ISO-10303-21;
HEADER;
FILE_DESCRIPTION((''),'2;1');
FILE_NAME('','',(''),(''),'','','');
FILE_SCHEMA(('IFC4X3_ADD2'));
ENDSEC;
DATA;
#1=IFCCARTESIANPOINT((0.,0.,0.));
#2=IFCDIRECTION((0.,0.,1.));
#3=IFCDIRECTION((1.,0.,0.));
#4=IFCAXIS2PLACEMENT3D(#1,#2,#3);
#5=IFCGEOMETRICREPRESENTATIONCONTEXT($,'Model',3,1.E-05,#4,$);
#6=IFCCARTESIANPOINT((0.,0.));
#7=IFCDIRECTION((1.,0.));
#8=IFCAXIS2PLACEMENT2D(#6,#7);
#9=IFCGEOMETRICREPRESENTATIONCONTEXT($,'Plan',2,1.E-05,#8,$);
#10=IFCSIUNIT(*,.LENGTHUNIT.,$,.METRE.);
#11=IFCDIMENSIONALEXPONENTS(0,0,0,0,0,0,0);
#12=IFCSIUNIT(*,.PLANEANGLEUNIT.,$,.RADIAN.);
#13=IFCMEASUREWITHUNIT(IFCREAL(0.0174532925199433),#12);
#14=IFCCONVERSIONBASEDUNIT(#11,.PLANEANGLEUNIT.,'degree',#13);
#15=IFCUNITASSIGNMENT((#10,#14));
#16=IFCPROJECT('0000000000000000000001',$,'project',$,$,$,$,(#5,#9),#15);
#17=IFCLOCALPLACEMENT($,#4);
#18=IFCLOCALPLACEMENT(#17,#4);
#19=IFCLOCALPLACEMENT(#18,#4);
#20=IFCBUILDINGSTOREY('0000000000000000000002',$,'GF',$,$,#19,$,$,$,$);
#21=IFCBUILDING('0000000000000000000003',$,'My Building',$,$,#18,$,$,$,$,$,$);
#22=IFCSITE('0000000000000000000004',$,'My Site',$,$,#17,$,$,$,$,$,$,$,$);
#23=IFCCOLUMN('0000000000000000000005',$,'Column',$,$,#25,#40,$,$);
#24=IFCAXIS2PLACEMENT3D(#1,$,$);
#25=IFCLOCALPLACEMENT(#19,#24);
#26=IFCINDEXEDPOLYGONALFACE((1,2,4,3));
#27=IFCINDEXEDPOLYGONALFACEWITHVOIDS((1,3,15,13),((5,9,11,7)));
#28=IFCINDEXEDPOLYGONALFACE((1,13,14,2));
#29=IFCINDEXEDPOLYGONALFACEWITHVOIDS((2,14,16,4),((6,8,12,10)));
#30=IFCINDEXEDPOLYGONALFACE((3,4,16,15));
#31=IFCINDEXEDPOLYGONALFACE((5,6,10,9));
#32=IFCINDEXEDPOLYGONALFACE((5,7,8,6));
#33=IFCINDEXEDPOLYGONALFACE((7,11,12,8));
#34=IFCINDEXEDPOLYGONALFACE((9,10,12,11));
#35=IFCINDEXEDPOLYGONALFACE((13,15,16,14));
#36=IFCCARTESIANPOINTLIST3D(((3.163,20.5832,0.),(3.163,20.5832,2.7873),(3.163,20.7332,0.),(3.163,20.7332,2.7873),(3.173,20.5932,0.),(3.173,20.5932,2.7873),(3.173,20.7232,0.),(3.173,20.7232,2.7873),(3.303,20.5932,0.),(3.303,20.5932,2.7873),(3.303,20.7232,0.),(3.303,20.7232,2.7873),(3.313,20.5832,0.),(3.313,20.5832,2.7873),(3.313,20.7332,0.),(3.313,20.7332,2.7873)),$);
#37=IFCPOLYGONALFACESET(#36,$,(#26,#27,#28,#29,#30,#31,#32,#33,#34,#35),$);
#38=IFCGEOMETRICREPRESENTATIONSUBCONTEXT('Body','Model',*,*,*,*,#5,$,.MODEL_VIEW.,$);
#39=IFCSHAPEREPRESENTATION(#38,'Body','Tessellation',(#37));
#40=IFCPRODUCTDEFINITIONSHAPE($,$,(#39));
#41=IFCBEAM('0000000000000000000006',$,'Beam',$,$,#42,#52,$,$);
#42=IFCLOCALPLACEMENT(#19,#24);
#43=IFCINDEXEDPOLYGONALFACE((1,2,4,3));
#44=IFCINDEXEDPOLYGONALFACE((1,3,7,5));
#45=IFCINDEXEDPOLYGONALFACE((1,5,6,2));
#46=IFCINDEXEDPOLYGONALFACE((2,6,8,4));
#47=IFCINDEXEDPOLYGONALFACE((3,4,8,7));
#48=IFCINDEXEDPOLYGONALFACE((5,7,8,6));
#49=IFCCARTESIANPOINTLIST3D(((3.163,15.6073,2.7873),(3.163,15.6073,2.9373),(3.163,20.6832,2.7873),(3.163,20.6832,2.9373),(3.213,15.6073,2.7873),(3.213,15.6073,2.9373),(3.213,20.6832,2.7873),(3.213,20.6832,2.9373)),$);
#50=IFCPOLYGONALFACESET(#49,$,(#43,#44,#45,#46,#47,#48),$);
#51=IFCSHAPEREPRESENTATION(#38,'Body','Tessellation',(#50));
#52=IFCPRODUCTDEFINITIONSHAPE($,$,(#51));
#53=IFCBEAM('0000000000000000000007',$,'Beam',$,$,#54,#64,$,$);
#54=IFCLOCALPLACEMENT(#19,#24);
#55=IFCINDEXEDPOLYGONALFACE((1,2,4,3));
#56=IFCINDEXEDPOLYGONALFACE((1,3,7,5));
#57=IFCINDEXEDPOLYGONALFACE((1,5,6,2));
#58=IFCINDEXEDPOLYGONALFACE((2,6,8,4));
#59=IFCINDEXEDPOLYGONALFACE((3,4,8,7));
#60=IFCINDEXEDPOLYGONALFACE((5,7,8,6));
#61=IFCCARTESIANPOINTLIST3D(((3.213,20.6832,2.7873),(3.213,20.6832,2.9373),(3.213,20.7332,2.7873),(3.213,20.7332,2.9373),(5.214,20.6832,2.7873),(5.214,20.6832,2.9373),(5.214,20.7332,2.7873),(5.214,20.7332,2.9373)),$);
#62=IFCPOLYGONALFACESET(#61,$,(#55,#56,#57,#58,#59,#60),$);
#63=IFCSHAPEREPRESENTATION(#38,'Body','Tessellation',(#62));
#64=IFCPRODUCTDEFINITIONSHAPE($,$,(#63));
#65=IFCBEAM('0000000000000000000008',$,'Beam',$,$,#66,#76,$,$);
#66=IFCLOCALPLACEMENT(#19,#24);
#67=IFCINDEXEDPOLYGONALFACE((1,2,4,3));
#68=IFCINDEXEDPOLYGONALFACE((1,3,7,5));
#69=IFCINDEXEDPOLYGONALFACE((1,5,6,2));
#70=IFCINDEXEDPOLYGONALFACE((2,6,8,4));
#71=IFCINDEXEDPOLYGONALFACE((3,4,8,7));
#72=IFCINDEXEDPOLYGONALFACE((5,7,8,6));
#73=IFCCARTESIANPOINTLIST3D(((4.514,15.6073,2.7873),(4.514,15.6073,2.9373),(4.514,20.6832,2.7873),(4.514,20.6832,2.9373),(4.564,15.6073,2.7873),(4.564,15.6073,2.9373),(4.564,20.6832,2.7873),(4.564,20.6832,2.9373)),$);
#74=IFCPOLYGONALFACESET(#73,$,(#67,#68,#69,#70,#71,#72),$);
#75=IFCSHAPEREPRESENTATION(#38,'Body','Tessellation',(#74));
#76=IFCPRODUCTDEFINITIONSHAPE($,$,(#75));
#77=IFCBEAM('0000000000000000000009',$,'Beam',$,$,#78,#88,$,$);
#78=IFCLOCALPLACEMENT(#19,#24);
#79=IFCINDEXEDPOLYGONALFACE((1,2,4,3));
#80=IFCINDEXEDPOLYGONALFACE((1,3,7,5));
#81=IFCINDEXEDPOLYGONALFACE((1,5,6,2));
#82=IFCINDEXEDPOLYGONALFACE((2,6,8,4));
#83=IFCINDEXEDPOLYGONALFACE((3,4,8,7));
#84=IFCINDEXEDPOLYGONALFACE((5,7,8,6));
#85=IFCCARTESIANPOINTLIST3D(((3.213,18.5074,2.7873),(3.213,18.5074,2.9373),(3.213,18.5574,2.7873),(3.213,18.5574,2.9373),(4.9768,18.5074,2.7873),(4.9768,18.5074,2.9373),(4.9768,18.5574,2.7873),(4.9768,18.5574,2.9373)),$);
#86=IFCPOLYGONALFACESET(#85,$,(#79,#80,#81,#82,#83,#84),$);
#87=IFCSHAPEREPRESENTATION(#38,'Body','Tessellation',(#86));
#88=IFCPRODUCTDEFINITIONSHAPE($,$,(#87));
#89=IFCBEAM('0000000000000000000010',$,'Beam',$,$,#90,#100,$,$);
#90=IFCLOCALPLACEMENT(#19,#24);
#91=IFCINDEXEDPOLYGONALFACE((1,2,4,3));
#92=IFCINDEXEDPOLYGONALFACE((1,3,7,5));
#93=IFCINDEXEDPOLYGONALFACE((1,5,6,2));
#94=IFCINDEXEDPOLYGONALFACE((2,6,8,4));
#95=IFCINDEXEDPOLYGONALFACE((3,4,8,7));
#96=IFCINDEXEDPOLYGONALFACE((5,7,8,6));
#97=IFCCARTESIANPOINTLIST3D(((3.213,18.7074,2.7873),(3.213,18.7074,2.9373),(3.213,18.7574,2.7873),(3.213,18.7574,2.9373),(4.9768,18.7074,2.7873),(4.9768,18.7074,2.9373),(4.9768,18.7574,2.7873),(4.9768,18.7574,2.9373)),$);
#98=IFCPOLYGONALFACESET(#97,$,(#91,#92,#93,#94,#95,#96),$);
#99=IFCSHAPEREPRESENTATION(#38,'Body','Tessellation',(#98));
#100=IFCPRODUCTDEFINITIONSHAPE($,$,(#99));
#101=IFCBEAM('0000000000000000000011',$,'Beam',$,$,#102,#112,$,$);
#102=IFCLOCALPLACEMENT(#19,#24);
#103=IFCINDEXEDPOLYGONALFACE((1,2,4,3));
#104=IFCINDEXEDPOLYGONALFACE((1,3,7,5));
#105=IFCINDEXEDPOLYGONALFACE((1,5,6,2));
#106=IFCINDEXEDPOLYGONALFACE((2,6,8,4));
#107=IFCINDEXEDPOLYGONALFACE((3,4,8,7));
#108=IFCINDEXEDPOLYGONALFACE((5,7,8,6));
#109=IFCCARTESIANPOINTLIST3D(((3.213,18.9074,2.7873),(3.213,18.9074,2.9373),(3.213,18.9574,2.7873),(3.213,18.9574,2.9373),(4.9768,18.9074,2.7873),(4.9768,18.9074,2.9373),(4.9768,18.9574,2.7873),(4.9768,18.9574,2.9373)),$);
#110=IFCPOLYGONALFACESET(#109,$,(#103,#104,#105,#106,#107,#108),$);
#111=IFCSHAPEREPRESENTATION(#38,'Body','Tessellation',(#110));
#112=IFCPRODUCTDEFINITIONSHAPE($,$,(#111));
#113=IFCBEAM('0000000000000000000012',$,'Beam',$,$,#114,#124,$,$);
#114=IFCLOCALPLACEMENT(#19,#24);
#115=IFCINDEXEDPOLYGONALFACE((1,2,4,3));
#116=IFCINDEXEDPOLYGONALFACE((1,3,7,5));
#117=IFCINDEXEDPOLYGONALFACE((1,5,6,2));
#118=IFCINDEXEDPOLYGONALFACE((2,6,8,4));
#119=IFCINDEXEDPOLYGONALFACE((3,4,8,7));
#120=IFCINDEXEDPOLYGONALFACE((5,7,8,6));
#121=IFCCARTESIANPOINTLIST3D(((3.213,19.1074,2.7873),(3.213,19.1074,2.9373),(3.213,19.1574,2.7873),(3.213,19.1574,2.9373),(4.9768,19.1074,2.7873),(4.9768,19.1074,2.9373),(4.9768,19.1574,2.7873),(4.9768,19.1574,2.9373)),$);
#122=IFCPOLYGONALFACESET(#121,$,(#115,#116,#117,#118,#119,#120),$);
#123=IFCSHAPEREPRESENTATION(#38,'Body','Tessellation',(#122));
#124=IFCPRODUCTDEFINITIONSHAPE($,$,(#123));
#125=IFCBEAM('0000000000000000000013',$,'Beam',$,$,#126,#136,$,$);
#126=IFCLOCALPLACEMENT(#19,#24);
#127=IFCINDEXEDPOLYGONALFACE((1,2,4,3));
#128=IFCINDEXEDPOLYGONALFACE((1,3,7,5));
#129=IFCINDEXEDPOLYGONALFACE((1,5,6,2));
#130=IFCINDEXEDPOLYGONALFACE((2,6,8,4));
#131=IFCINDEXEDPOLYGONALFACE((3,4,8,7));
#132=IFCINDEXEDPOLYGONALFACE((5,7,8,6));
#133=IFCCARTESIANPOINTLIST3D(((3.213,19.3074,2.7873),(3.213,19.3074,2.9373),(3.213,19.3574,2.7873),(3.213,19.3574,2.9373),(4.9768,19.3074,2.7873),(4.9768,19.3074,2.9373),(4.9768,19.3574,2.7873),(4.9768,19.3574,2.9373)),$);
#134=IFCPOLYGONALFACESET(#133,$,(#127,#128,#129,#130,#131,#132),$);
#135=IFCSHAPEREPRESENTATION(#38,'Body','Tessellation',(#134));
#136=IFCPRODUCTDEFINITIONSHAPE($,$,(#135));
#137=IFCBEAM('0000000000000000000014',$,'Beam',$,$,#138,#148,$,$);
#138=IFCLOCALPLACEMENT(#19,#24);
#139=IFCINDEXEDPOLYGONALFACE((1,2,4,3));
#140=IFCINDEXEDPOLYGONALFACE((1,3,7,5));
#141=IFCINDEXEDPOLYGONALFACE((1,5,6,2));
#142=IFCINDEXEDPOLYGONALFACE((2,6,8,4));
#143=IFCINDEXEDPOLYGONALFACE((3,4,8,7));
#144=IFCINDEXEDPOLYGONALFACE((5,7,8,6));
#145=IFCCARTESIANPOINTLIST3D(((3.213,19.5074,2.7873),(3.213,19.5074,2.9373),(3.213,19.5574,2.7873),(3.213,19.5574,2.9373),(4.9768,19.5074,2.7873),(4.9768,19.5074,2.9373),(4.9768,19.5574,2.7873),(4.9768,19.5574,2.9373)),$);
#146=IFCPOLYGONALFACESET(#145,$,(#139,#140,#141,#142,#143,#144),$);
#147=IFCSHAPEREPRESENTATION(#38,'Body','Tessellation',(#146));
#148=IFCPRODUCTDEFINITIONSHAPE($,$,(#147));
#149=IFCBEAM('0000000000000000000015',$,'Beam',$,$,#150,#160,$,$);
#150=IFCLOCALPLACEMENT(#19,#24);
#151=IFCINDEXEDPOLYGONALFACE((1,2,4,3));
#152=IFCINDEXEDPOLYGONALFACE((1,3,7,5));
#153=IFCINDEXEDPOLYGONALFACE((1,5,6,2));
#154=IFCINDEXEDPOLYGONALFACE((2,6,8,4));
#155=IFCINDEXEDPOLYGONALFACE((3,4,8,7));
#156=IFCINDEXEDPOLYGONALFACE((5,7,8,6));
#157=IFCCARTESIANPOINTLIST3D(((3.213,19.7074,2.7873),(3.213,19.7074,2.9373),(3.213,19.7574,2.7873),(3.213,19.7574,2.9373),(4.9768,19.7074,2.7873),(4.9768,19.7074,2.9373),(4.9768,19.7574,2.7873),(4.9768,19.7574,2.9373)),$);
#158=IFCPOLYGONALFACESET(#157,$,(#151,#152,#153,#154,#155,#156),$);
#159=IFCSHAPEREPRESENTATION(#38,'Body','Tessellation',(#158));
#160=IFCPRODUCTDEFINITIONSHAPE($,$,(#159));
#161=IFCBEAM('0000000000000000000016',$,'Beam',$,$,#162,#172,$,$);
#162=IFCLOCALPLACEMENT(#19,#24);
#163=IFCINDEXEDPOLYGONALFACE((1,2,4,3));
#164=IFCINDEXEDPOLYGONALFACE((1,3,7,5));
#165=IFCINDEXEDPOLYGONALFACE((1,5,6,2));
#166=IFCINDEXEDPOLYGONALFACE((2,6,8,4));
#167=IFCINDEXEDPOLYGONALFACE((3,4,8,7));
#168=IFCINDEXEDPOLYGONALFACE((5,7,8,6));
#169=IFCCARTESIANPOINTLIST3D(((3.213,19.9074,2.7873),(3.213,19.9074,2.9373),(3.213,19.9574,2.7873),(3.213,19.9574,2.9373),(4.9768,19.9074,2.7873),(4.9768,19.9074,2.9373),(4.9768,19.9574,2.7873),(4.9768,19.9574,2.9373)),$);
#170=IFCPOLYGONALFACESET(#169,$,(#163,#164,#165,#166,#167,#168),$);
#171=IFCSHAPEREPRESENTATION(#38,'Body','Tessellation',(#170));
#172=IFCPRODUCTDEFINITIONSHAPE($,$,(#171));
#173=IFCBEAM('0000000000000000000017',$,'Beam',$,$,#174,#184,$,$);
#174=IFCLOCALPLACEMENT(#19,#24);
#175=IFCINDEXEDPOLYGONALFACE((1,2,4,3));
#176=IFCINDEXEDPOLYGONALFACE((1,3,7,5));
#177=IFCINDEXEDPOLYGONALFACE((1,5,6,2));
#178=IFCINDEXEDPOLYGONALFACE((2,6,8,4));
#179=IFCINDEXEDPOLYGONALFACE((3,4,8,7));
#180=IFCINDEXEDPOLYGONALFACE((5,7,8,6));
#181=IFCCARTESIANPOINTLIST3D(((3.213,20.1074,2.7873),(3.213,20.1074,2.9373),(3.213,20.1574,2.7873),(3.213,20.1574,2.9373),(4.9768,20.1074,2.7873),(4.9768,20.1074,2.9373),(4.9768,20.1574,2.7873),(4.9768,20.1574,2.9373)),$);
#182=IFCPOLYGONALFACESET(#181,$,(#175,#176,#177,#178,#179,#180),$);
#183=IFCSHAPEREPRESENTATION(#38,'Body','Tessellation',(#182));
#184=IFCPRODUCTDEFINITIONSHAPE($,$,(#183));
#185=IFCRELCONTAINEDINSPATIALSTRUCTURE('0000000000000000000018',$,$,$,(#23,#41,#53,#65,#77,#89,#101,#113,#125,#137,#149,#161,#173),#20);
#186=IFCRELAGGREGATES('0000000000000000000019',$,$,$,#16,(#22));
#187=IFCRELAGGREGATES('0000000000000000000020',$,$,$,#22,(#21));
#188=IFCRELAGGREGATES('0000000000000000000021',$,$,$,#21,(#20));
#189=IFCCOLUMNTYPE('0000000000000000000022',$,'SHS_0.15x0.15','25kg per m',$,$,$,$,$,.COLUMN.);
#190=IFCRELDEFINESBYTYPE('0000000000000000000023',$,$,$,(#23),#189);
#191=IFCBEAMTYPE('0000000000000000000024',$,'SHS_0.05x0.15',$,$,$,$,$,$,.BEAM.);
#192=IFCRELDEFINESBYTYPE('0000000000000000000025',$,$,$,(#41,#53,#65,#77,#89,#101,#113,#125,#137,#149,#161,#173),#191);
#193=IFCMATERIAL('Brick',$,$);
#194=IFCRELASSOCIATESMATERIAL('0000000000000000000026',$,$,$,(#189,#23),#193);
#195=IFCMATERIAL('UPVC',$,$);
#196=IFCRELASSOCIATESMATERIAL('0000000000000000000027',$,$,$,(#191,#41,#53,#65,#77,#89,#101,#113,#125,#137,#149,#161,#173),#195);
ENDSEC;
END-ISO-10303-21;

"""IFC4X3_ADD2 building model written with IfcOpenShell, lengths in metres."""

from ifc_helpers import new_model, entity, si_unit, converted_unit, frame, origin_with_axes, origin_2d_with_axis, place, context, subcontext, project, spatial, rectangle, hollow_rectangle, extrude, shape, material, material_profile, profile_set, profile_usage, type_object, element, save


model = new_model("IFC4X3_ADD2")

# Units and contexts
model_context = context("Model", 3, precision=1e-05, world=origin_with_axes())
plan_context = context("Plan", 2, precision=1e-05, world=origin_2d_with_axis())
body_context_1 = subcontext(model_context, "Body", "Model", "MODEL_VIEW")
body_context_2 = subcontext(plan_context, "Body", "Plan", "PLAN_VIEW")
ifc_project = project(units=[si_unit("LENGTHUNIT", "METRE"), converted_unit("PLANEANGLEUNIT", "degree", entity("IfcReal", 0.0174532925199433), si_unit("PLANEANGLEUNIT", "RADIAN"), dimensions=[0, 0, 0, 0, 0, 0, 0])], contexts=[model_context, plan_context])

# Site, building, storey
site_placement = place(None, origin_with_axes())
site = spatial("IfcSite", under=ifc_project, at=site_placement, Name="My Site")
building_placement = place(site_placement, origin_with_axes())
building = spatial("IfcBuilding", under=site, at=building_placement, Name="My Building")
storey_placement = place(building_placement, origin_with_axes())
storey = spatial("IfcBuildingStorey", under=building, at=storey_placement, Name="GF")

# Column
ifc_material_1 = material(Name="Brick")
ifc_material_profile_1 = material_profile(ifc_material_1, hollow_rectangle(XDim=0.15, YDim=0.15, WallThickness=0.01))
ifc_profile_set_1 = profile_set([ifc_material_profile_1])
ifc_profile_usage_1 = profile_usage(ifc_profile_set_1, cardinal=5)
column_type = type_object("IfcColumnType", Name="SHS_0.15x0.15", Description="25kg per m", PredefinedType="COLUMN", material=ifc_profile_set_1)
column_placement = place(storey_placement, frame((3.238, 20.6582, 0.0), z_axis=(0.0, 0.0, 1.0), x_axis=(1.0, 0.0, 0.0)))
element("IfcColumn", 1, at=column_placement, inside=storey, type_object=column_type, material=ifc_profile_usage_1, Name="Column", shapes=[
    shape(body_context_1, "Body", "SweptSolid", [extrude(hollow_rectangle(XDim=0.15, YDim=0.15, WallThickness=0.01), origin_with_axes(), (0.0, 0.0, 1.0), 2.7873)]),
    shape(body_context_2, "Body", "Annotation2D", [entity("IfcGeometricCurveSet", [entity("IfcIndexedPolyCurve", entity("IfcCartesianPointList2D", [[-0.075, -0.075], [0.075, -0.075], [0.075, 0.075], [-0.075, 0.075]]), [entity("IfcLineIndex", [1, 2, 3, 4, 1])]), entity("IfcIndexedPolyCurve", entity("IfcCartesianPointList2D", [[-0.065, 0.065], [0.065, 0.065], [0.065, -0.065], [-0.065, -0.065]]), [entity("IfcLineIndex", [1, 2, 3, 4, 1])])])]),
])

# Beams
ifc_material_2 = material(Name="UPVC")
ifc_material_profile_2 = material_profile(ifc_material_2, rectangle(XDim=0.05, YDim=0.15))
ifc_profile_set_2 = profile_set([ifc_material_profile_2])
ifc_profile_usage_2 = profile_usage(ifc_profile_set_2)
beam_type = type_object("IfcBeamType", Name="SHS_0.05x0.15", PredefinedType="BEAM", material=ifc_profile_set_2)
beam_1_placement = place(storey_placement, frame((3.188, 20.6832, 2.8623), z_axis=(0.0, -1.0, 0.0), x_axis=(1.0, 0.0, 0.0)))
element("IfcBeam", 2, at=beam_1_placement, inside=storey, type_object=beam_type, material=ifc_profile_usage_2, Name="Beam", context=body_context_1, shape_type="SweptSolid", body=[
    extrude(rectangle(XDim=0.05, YDim=0.15), origin_with_axes(), (0.0, 0.0, 1.0), 5.0758),
])
ifc_profile_usage_3 = profile_usage(ifc_profile_set_2)
beam_2_placement = place(storey_placement, frame((3.213, 20.7082, 2.8623), z_axis=(1.0, 0.0, 0.0), x_axis=(0.0, 1.0, 0.0)))
element("IfcBeam", 3, at=beam_2_placement, inside=storey, type_object=beam_type, material=ifc_profile_usage_3, Name="Beam", context=body_context_1, shape_type="SweptSolid", body=[
    extrude(rectangle(XDim=0.05, YDim=0.15), origin_with_axes(), (0.0, 0.0, 1.0), 2.001),
])
ifc_profile_usage_4 = profile_usage(ifc_profile_set_2)
beam_3_placement = place(storey_placement, frame((4.539, 20.6832, 2.8623), z_axis=(0.0, -1.0, 0.0), x_axis=(1.0, 0.0, 0.0)))
element("IfcBeam", 4, at=beam_3_placement, inside=storey, type_object=beam_type, material=ifc_profile_usage_4, Name="Beam", context=body_context_1, shape_type="SweptSolid", body=[
    extrude(rectangle(XDim=0.05, YDim=0.15), origin_with_axes(), (0.0, 0.0, 1.0), 5.0758),
])
ifc_profile_usage_5 = profile_usage(ifc_profile_set_2)
beam_4_placement = place(storey_placement, frame((3.213, 18.5324, 2.8623), z_axis=(1.0, 0.0, 0.0), x_axis=(0.0, 1.0, 0.0)))
element("IfcBeam", 5, at=beam_4_placement, inside=storey, type_object=beam_type, material=ifc_profile_usage_5, Name="Beam", context=body_context_1, shape_type="SweptSolid", body=[
    extrude(rectangle(XDim=0.05, YDim=0.15), origin_with_axes(), (0.0, 0.0, 1.0), 1.7638),
])
ifc_profile_usage_6 = profile_usage(ifc_profile_set_2)
beam_5_placement = place(storey_placement, frame((3.213, 18.7324, 2.8623), z_axis=(1.0, 0.0, 0.0), x_axis=(0.0, 1.0, 0.0)))
element("IfcBeam", 6, at=beam_5_placement, inside=storey, type_object=beam_type, material=ifc_profile_usage_6, Name="Beam", context=body_context_1, shape_type="SweptSolid", body=[
    extrude(rectangle(XDim=0.05, YDim=0.15), origin_with_axes(), (0.0, 0.0, 1.0), 1.7638),
])
ifc_profile_usage_7 = profile_usage(ifc_profile_set_2)
beam_6_placement = place(storey_placement, frame((3.213, 18.9324, 2.8623), z_axis=(1.0, 0.0, 0.0), x_axis=(0.0, 1.0, 0.0)))
element("IfcBeam", 7, at=beam_6_placement, inside=storey, type_object=beam_type, material=ifc_profile_usage_7, Name="Beam", context=body_context_1, shape_type="SweptSolid", body=[
    extrude(rectangle(XDim=0.05, YDim=0.15), origin_with_axes(), (0.0, 0.0, 1.0), 1.7638),
])
ifc_profile_usage_8 = profile_usage(ifc_profile_set_2)
beam_7_placement = place(storey_placement, frame((3.213, 19.1324, 2.8623), z_axis=(1.0, 0.0, 0.0), x_axis=(0.0, 1.0, 0.0)))
element("IfcBeam", 8, at=beam_7_placement, inside=storey, type_object=beam_type, material=ifc_profile_usage_8, Name="Beam", context=body_context_1, shape_type="SweptSolid", body=[
    extrude(rectangle(XDim=0.05, YDim=0.15), origin_with_axes(), (0.0, 0.0, 1.0), 1.7638),
])
ifc_profile_usage_9 = profile_usage(ifc_profile_set_2)
beam_8_placement = place(storey_placement, frame((3.213, 19.3324, 2.8623), z_axis=(1.0, 0.0, 0.0), x_axis=(0.0, 1.0, 0.0)))
element("IfcBeam", 9, at=beam_8_placement, inside=storey, type_object=beam_type, material=ifc_profile_usage_9, Name="Beam", context=body_context_1, shape_type="SweptSolid", body=[
    extrude(rectangle(XDim=0.05, YDim=0.15), origin_with_axes(), (0.0, 0.0, 1.0), 1.7638),
])
ifc_profile_usage_10 = profile_usage(ifc_profile_set_2)
beam_9_placement = place(storey_placement, frame((3.213, 19.5324, 2.8623), z_axis=(1.0, 0.0, 0.0), x_axis=(0.0, 1.0, 0.0)))
element("IfcBeam", 10, at=beam_9_placement, inside=storey, type_object=beam_type, material=ifc_profile_usage_10, Name="Beam", context=body_context_1, shape_type="SweptSolid", body=[
    extrude(rectangle(XDim=0.05, YDim=0.15), origin_with_axes(), (0.0, 0.0, 1.0), 1.7638),
])
ifc_profile_usage_11 = profile_usage(ifc_profile_set_2)
beam_10_placement = place(storey_placement, frame((3.213, 19.7324, 2.8623), z_axis=(1.0, 0.0, 0.0), x_axis=(0.0, 1.0, 0.0)))
element("IfcBeam", 11, at=beam_10_placement, inside=storey, type_object=beam_type, material=ifc_profile_usage_11, Name="Beam", context=body_context_1, shape_type="SweptSolid", body=[
    extrude(rectangle(XDim=0.05, YDim=0.15), origin_with_axes(), (0.0, 0.0, 1.0), 1.7638),
])
ifc_profile_usage_12 = profile_usage(ifc_profile_set_2)
beam_11_placement = place(storey_placement, frame((3.213, 19.9324, 2.8623), z_axis=(1.0, 0.0, 0.0), x_axis=(0.0, 1.0, 0.0)))
element("IfcBeam", 12, at=beam_11_placement, inside=storey, type_object=beam_type, material=ifc_profile_usage_12, Name="Beam", context=body_context_1, shape_type="SweptSolid", body=[
    extrude(rectangle(XDim=0.05, YDim=0.15), origin_with_axes(), (0.0, 0.0, 1.0), 1.7638),
])
ifc_profile_usage_13 = profile_usage(ifc_profile_set_2)
beam_12_placement = place(storey_placement, frame((3.213, 20.1324, 2.8623), z_axis=(1.0, 0.0, 0.0), x_axis=(0.0, 1.0, 0.0)))
element("IfcBeam", 13, at=beam_12_placement, inside=storey, type_object=beam_type, material=ifc_profile_usage_13, Name="Beam", context=body_context_1, shape_type="SweptSolid", body=[
    extrude(rectangle(XDim=0.05, YDim=0.15), origin_with_axes(), (0.0, 0.0, 1.0), 1.7638),
])

save(model, "model.ifc")
